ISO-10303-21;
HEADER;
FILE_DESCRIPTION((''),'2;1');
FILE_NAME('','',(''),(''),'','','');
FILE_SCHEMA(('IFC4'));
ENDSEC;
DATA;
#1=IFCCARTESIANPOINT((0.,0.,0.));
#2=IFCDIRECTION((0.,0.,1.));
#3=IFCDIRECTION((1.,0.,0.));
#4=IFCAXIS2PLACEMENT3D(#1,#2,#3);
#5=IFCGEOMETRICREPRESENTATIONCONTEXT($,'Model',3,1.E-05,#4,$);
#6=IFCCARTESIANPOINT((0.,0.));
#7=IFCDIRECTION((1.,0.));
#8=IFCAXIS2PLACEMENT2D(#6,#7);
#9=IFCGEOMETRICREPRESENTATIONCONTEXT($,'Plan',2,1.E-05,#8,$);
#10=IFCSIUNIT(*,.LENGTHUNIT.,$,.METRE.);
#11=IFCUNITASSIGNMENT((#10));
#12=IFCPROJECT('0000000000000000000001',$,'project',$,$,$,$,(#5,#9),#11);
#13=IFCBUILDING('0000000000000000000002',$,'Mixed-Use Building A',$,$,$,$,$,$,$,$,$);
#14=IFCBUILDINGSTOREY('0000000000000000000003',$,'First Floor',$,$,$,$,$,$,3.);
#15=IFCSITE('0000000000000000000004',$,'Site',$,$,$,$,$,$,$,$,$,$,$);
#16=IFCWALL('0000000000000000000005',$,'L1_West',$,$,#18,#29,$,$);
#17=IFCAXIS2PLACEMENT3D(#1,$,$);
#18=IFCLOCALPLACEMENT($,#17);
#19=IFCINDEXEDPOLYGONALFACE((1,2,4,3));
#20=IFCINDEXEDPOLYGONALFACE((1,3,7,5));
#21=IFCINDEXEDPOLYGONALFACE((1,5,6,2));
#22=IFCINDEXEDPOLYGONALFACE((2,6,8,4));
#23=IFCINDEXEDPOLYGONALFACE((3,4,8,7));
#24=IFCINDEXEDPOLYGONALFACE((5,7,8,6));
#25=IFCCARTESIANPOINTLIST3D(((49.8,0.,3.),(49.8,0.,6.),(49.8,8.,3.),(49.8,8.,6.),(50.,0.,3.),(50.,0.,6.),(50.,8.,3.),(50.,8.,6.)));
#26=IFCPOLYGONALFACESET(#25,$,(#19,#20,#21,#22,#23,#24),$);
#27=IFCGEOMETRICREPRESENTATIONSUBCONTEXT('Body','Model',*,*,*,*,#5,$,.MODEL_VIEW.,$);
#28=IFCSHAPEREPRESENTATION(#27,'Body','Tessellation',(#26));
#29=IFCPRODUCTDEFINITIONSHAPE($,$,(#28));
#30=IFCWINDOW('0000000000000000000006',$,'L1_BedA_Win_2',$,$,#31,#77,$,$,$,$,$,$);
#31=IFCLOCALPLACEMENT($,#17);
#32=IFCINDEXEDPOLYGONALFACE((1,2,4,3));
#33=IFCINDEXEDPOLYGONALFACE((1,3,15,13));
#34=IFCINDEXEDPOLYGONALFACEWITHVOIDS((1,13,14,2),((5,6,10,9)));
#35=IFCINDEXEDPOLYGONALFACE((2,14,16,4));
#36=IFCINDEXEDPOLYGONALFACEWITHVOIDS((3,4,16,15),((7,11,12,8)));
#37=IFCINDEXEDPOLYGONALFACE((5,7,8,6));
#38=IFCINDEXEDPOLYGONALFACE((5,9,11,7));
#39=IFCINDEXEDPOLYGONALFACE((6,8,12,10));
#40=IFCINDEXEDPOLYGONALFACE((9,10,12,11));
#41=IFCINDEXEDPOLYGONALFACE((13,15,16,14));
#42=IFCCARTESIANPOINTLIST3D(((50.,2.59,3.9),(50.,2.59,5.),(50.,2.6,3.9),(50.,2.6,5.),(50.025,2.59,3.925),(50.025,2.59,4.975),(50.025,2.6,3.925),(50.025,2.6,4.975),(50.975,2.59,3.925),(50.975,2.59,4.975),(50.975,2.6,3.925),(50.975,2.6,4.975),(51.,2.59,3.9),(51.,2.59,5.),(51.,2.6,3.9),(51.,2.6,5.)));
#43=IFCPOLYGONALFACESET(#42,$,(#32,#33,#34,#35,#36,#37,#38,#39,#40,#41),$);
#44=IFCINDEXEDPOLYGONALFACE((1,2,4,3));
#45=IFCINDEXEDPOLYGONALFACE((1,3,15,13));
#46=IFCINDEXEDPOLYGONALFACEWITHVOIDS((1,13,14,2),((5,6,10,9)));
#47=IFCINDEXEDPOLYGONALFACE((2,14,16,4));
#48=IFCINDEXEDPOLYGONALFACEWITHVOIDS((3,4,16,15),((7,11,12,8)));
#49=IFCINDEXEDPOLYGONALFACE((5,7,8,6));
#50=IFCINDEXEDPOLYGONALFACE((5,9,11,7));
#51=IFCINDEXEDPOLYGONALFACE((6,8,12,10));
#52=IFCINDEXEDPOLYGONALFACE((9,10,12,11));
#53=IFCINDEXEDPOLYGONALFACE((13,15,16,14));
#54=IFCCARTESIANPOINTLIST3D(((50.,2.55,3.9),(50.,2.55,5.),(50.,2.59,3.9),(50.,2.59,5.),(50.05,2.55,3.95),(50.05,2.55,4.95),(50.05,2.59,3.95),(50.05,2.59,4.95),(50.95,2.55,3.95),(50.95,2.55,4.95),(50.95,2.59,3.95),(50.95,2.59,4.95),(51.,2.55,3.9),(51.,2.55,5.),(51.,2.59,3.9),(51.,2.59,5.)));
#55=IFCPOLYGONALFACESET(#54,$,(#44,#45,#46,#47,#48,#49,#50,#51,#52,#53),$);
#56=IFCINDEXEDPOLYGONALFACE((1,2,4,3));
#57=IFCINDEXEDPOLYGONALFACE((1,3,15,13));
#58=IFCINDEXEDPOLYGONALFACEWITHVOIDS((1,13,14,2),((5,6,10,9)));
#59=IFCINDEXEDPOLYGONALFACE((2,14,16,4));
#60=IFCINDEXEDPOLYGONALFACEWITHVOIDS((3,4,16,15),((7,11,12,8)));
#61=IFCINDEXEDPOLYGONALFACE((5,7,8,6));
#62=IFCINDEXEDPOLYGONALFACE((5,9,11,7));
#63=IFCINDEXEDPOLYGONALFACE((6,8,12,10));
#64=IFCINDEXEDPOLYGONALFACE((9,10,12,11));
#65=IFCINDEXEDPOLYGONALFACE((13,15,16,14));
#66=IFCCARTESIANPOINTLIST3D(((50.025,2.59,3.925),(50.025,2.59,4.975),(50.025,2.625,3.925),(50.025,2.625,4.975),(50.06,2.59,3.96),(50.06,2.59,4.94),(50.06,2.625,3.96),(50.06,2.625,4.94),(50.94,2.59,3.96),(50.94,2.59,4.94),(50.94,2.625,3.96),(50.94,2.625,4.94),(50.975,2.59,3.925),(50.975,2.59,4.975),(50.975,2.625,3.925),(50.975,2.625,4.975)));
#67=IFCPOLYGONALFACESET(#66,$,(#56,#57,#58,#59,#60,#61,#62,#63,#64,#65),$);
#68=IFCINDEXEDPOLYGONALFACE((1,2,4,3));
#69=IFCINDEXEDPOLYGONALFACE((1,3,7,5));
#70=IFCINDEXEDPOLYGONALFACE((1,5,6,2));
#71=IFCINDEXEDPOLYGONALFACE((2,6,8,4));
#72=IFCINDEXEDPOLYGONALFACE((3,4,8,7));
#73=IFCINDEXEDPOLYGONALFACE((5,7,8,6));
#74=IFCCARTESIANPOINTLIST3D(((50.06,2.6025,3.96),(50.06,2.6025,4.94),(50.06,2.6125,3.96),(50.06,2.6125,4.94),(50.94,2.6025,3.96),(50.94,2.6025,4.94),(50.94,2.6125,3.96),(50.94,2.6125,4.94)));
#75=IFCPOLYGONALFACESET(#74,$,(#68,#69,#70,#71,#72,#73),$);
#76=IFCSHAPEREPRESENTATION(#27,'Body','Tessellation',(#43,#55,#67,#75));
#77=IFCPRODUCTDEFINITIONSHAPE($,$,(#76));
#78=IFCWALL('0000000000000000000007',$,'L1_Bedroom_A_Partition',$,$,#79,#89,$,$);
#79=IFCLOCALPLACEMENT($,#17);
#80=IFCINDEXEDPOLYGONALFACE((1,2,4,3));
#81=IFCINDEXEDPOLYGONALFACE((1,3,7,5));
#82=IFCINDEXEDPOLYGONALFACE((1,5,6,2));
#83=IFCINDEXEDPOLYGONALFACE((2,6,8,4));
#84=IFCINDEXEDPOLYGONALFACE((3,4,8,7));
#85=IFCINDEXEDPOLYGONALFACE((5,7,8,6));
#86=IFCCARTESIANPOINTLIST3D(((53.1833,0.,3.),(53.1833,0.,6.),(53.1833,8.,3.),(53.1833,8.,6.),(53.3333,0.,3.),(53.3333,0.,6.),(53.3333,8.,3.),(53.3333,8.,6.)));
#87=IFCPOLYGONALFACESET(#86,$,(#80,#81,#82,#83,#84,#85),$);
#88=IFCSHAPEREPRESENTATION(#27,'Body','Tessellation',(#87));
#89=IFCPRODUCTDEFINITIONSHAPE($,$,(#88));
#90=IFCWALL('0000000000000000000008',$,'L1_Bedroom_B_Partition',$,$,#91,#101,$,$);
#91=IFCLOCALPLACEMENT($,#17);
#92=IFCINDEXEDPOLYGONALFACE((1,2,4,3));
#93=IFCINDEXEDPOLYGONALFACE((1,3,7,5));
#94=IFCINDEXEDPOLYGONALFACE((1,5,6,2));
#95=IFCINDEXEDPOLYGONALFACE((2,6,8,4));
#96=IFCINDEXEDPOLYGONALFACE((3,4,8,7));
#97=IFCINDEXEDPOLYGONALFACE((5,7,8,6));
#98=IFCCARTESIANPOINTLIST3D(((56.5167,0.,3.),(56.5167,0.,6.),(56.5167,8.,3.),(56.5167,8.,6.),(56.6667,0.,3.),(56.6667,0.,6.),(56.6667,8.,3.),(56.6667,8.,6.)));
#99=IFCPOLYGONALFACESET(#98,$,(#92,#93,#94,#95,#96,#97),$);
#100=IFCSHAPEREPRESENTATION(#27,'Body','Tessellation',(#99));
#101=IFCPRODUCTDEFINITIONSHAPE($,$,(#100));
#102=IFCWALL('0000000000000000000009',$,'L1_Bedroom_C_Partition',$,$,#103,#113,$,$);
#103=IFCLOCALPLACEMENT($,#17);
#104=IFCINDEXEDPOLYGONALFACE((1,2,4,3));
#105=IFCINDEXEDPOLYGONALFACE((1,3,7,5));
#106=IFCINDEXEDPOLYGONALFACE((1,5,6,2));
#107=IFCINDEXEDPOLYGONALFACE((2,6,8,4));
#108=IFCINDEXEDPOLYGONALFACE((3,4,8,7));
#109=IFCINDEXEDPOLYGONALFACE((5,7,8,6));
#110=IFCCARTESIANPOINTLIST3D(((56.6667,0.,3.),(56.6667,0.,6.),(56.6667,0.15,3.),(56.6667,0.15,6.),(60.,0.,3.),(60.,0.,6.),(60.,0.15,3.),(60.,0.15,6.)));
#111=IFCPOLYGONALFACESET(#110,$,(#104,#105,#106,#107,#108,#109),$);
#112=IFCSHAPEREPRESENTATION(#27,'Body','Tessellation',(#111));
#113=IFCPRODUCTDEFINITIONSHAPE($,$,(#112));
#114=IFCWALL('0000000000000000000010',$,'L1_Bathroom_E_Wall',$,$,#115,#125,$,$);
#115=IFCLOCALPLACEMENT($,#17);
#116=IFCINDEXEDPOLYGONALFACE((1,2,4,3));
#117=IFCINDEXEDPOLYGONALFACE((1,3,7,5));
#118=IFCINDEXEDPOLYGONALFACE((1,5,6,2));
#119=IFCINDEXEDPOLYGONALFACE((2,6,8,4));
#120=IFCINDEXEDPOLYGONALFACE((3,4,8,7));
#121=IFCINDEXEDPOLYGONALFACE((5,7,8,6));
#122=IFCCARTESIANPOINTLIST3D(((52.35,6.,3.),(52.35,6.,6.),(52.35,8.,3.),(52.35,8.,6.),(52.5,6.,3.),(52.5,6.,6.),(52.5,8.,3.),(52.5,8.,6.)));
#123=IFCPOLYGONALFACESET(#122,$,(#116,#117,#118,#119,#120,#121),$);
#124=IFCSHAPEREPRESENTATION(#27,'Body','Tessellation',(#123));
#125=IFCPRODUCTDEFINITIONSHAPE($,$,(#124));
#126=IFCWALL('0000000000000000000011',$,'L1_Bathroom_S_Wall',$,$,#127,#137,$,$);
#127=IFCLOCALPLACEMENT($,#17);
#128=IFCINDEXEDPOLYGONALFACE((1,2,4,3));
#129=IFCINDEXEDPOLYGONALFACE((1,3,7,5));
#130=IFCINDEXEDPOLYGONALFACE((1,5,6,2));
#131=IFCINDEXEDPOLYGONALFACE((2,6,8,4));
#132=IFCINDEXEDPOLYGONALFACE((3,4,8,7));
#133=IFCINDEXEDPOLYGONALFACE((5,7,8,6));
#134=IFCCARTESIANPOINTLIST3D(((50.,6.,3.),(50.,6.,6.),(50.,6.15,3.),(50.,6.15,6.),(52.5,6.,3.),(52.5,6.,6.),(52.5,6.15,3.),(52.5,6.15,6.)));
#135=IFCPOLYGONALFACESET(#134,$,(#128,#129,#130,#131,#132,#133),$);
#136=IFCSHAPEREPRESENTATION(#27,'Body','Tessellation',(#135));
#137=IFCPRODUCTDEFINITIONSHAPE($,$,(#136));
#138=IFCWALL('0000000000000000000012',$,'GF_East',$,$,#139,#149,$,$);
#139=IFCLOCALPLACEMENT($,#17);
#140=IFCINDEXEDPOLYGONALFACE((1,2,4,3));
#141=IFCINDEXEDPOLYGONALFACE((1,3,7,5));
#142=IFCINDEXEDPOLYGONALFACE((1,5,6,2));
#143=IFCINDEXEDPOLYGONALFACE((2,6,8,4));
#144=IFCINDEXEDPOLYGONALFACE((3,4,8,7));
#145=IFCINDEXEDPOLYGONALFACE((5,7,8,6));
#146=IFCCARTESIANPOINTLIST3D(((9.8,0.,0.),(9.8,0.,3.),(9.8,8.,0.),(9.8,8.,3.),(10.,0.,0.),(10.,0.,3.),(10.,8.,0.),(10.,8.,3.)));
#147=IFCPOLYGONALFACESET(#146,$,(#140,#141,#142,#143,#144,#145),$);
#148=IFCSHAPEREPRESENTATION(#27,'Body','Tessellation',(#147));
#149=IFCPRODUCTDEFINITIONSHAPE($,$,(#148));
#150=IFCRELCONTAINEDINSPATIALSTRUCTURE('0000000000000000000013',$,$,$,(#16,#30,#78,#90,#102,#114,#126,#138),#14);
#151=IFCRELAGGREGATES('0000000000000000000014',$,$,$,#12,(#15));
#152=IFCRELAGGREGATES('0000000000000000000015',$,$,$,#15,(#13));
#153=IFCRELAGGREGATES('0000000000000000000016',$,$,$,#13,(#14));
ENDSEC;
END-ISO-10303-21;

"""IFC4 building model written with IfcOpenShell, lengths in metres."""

from ifc_helpers import new_model, si_unit, frame, origin_with_axes, origin_2d_with_axis, place, context, subcontext, project, spatial, line, indexed_curve, outline, extrude, element, fill, save


model = new_model("IFC4")

# Units and contexts
model_context = context("Model", 3, precision=1e-05, world=origin_with_axes())
plan_context = context("Plan", 2, precision=1e-05, world=origin_2d_with_axis())
body_context = subcontext(model_context, "Body", "Model", "MODEL_VIEW")
ifc_project = project(units=[si_unit("LENGTHUNIT", "METRE")], contexts=[model_context, plan_context])

# Site, building, storey
site = spatial("IfcSite", under=ifc_project, Name="Site")
building = spatial("IfcBuilding", under=site, Name="Mixed-Use Building A")
storey = spatial("IfcBuildingStorey", under=building, Name="First Floor", Elevation=3.0)

# Wall, opening, window
wall_1_placement = place(None, frame((50.0, 0.0, 3.0), z_axis=(0.0, 0.0, 1.0), x_axis=(0.0, 1.0, 0.0)))
wall_1 = element("IfcWall", 1, at=wall_1_placement, inside=storey, Name="L1_West", context=body_context, shape_type="SweptSolid", body=[
    extrude(outline(indexed_curve([(0.0, 0.0), (0.0, 0.2), (8.0, 0.2), (8.0, 0.0), (0.0, 0.0)], self_intersect=False)), origin_with_axes(), (0.0, 0.0, 1.0), 3.0),
])
opening_1_placement = place(wall_1_placement, frame((2.5, 0.0, 0.9), z_axis=(0.0, 0.0, 1.0), x_axis=(0.0, -1.0, 0.0)))
opening_1 = element("IfcOpeningElement", 2, at=opening_1_placement, cuts=wall_1, context=body_context, shape_type="SweptSolid", body=[
    extrude(outline(indexed_curve([(0.0, 0.0), (0.0, 0.3), (1.0, 0.3), (1.0, 0.0), (0.0, 0.0)], self_intersect=False)), origin_with_axes(), (0.0, 0.0, 1.0), 1.1),
])
window_1_placement = place(None, frame((50.0, 2.5, 3.9), z_axis=(0.0, 0.0, 1.0), x_axis=(1.0, 0.0, 0.0)))
window_1 = element("IfcWindow", 3, at=window_1_placement, inside=storey, Name="L1_BedA_Win_2", context=body_context, shape_type="SweptSolid", body=[
    extrude(outline(indexed_curve([(0.0, 0.0), (1.0, 0.0), (1.0, 1.1), (0.0, 1.1)], segments=[line(1, 2, 3, 4, 1)]), holes=[indexed_curve([(0.025, 0.025), (0.975, 0.025), (0.975, 1.075), (0.025, 1.075)], segments=[line(1, 2, 3, 4, 1)])]), frame((0.0, 0.09, 0.0), z_axis=(0.0, -1.0, 0.0), x_axis=(1.0, 0.0, 0.0)), (0.0, 0.0, -1.0), 0.01),
    extrude(outline(indexed_curve([(0.0, 0.0), (1.0, 0.0), (1.0, 1.1), (0.0, 1.1)], segments=[line(1, 2, 3, 4, 1)]), holes=[indexed_curve([(0.05, 0.05), (0.95, 0.05), (0.95, 1.05), (0.05, 1.05)], segments=[line(1, 2, 3, 4, 1)])]), frame((0.0, 0.05, 0.0), z_axis=(0.0, -1.0, 0.0), x_axis=(1.0, 0.0, 0.0)), (0.0, 0.0, -1.0), 0.04),
    extrude(outline(indexed_curve([(0.0, 0.0), (0.95, 0.0), (0.95, 1.05), (0.0, 1.05)], segments=[line(1, 2, 3, 4, 1)]), holes=[indexed_curve([(0.035, 0.035), (0.915, 0.035), (0.915, 1.015), (0.035, 1.015)], segments=[line(1, 2, 3, 4, 1)])]), frame((0.025, 0.09, 0.025), z_axis=(0.0, -1.0, 0.0), x_axis=(1.0, 0.0, 0.0)), (0.0, 0.0, -1.0), 0.035),
    extrude(outline(indexed_curve([(0.035, 0.035), (0.915, 0.035), (0.915, 1.015), (0.035, 1.015)], segments=[line(1, 2, 3, 4, 1)])), frame((0.025, 0.1025, 0.025), z_axis=(0.0, -1.0, 0.0), x_axis=(1.0, 0.0, 0.0)), (0.0, 0.0, -1.0), 0.01),
])
fill(opening_1, window_1)

# Walls
for number, where, z_axis, x_axis, name in (
    (4, (53.3333, 0.0, 3.0), (0.0, 0.0, 1.0), (0.0, 1.0, 0.0), "L1_Bedroom_A_Partition"),
    (5, (56.6667, 0.0, 3.0), (0.0, 0.0, 1.0), (0.0, 1.0, 0.0), "L1_Bedroom_B_Partition"),
):
    element("IfcWall", number, at=place(None, frame(where, z_axis=z_axis, x_axis=x_axis)), inside=storey, Name=name, context=body_context, shape_type="SweptSolid", body=[
        extrude(outline(indexed_curve([(0.0, 0.0), (0.0, 0.15), (8.0, 0.15), (8.0, 0.0), (0.0, 0.0)], self_intersect=False)), origin_with_axes(), (0.0, 0.0, 1.0), 3.0),
    ])
wall_2_placement = place(None, frame((56.6667, 0.0, 3.0), z_axis=(0.0, 0.0, 1.0), x_axis=(1.0, 0.0, 0.0)))
element("IfcWall", 6, at=wall_2_placement, inside=storey, Name="L1_Bedroom_C_Partition", context=body_context, shape_type="SweptSolid", body=[
    extrude(outline(indexed_curve([(0.0, 0.0), (0.0, 0.15), (3.3333, 0.15), (3.3333, 0.0), (0.0, 0.0)], self_intersect=False)), origin_with_axes(), (0.0, 0.0, 1.0), 3.0),
])
wall_3_placement = place(None, frame((52.5, 6.0, 3.0), z_axis=(0.0, 0.0, 1.0), x_axis=(0.0, 1.0, 0.0)))
element("IfcWall", 7, at=wall_3_placement, inside=storey, Name="L1_Bathroom_E_Wall", context=body_context, shape_type="SweptSolid", body=[
    extrude(outline(indexed_curve([(0.0, 0.0), (0.0, 0.15), (2.0, 0.15), (2.0, 0.0), (0.0, 0.0)], self_intersect=False)), origin_with_axes(), (0.0, 0.0, 1.0), 3.0),
])
wall_4_placement = place(None, frame((50.0, 6.0, 3.0), z_axis=(0.0, 0.0, 1.0), x_axis=(1.0, 0.0, 0.0)))
element("IfcWall", 8, at=wall_4_placement, inside=storey, Name="L1_Bathroom_S_Wall", context=body_context, shape_type="SweptSolid", body=[
    extrude(outline(indexed_curve([(0.0, 0.0), (0.0, 0.15), (2.5, 0.15), (2.5, 0.0), (0.0, 0.0)], self_intersect=False)), origin_with_axes(), (0.0, 0.0, 1.0), 3.0),
])
wall_5_placement = place(None, frame((10.0, 0.0, 0.0), z_axis=(0.0, 0.0, 1.0), x_axis=(0.0, 1.0, 0.0)))
element("IfcWall", 9, at=wall_5_placement, inside=storey, Name="GF_East", context=body_context, shape_type="SweptSolid", body=[
    extrude(outline(indexed_curve([(0.0, 0.0), (0.0, 0.2), (8.0, 0.2), (8.0, 0.0), (0.0, 0.0)], self_intersect=False)), origin_with_axes(), (0.0, 0.0, 1.0), 3.0),
])

save(model, "model.ifc")
